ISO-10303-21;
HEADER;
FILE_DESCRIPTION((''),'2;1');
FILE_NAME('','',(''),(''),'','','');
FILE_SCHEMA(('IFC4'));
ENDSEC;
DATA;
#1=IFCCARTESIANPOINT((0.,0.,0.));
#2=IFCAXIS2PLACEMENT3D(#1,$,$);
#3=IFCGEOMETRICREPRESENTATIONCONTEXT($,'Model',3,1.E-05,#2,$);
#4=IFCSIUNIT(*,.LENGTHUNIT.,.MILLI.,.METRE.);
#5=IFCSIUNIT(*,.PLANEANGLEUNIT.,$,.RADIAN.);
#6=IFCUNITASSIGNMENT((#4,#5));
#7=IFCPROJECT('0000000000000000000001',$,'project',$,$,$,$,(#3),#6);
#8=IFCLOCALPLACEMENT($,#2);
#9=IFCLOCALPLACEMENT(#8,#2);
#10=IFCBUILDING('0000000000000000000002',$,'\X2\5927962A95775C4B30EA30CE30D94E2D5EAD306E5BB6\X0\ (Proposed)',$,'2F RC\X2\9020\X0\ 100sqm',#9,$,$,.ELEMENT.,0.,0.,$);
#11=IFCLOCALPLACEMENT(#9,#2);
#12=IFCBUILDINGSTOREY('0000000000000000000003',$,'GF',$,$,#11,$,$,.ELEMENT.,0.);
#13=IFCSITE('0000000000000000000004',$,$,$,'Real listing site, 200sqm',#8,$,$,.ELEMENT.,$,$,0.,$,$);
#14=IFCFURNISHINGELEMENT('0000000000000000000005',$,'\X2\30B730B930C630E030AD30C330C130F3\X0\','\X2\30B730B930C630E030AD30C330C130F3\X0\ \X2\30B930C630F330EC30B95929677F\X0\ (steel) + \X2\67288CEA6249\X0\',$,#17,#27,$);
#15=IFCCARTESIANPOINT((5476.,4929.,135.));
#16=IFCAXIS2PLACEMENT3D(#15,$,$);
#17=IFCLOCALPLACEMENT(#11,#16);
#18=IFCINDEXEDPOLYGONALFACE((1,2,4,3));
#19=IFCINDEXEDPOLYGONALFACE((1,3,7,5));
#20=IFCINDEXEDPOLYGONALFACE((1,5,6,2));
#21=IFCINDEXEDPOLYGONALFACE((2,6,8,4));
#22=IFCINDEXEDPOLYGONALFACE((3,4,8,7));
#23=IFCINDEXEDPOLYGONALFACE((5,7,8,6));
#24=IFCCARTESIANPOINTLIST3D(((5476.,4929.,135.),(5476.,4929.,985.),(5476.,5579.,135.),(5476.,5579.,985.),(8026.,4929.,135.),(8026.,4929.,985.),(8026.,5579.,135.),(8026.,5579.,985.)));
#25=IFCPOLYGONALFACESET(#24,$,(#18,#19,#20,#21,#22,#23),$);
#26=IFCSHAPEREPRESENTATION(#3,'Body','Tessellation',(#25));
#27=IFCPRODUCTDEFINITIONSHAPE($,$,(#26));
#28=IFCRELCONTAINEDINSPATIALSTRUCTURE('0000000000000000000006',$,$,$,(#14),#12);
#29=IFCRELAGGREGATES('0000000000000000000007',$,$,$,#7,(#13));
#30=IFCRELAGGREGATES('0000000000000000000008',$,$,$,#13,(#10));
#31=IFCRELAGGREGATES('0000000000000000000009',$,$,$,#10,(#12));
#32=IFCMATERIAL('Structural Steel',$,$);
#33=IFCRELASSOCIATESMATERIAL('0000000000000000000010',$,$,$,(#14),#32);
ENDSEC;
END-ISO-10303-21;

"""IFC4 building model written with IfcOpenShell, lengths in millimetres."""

from ifc_helpers import new_model, si_unit, frame, frame_2d, origin, place, context, project, spatial, rectangle, extrude, material, element, save


model = new_model("IFC4")

# Units and contexts
model_context = context("Model", 3, precision=1e-05, world=origin())
ifc_project = project(units=[si_unit("LENGTHUNIT", "METRE", prefix="MILLI"), si_unit("PLANEANGLEUNIT", "RADIAN")], contexts=[model_context])

# Site, building, storey
site_placement = place(None, origin())
site = spatial("IfcSite", under=ifc_project, at=site_placement, ObjectType="Real listing site, 200sqm", CompositionType="ELEMENT", RefElevation=0.0)
building_placement = place(site_placement, origin())
building = spatial("IfcBuilding", under=site, at=building_placement, Name="大阪長屋リノベ中庭の家 (Proposed)", ObjectType="2F RC造 100sqm", CompositionType="ELEMENT", ElevationOfRefHeight=0.0, ElevationOfTerrain=0.0)
storey_placement = place(building_placement, origin())
storey = spatial("IfcBuildingStorey", under=building, at=storey_placement, Name="GF", CompositionType="ELEMENT", Elevation=0.0)

# Shared definitions
ifc_material_1 = material(Name="Structural Steel")

# Furnishing element
furnishing_placement = place(storey_placement, frame((5476.0, 4929.0, 135.0)))
element("IfcFurnishingElement", 1, at=furnishing_placement, inside=storey, material=ifc_material_1, Name="システムキッチン", Description="システムキッチン ステンレス天板 (steel) + 木質扉", context=model_context, shape_type="SweptSolid", body=[
    extrude(rectangle(XDim=2550.0, YDim=650.0, at=frame_2d((1275.0, 325.0))), frame((5476.0, 4929.0, 135.0)), (0.0, 0.0, 1.0), 850.0),
])

save(model, "model.ifc")
